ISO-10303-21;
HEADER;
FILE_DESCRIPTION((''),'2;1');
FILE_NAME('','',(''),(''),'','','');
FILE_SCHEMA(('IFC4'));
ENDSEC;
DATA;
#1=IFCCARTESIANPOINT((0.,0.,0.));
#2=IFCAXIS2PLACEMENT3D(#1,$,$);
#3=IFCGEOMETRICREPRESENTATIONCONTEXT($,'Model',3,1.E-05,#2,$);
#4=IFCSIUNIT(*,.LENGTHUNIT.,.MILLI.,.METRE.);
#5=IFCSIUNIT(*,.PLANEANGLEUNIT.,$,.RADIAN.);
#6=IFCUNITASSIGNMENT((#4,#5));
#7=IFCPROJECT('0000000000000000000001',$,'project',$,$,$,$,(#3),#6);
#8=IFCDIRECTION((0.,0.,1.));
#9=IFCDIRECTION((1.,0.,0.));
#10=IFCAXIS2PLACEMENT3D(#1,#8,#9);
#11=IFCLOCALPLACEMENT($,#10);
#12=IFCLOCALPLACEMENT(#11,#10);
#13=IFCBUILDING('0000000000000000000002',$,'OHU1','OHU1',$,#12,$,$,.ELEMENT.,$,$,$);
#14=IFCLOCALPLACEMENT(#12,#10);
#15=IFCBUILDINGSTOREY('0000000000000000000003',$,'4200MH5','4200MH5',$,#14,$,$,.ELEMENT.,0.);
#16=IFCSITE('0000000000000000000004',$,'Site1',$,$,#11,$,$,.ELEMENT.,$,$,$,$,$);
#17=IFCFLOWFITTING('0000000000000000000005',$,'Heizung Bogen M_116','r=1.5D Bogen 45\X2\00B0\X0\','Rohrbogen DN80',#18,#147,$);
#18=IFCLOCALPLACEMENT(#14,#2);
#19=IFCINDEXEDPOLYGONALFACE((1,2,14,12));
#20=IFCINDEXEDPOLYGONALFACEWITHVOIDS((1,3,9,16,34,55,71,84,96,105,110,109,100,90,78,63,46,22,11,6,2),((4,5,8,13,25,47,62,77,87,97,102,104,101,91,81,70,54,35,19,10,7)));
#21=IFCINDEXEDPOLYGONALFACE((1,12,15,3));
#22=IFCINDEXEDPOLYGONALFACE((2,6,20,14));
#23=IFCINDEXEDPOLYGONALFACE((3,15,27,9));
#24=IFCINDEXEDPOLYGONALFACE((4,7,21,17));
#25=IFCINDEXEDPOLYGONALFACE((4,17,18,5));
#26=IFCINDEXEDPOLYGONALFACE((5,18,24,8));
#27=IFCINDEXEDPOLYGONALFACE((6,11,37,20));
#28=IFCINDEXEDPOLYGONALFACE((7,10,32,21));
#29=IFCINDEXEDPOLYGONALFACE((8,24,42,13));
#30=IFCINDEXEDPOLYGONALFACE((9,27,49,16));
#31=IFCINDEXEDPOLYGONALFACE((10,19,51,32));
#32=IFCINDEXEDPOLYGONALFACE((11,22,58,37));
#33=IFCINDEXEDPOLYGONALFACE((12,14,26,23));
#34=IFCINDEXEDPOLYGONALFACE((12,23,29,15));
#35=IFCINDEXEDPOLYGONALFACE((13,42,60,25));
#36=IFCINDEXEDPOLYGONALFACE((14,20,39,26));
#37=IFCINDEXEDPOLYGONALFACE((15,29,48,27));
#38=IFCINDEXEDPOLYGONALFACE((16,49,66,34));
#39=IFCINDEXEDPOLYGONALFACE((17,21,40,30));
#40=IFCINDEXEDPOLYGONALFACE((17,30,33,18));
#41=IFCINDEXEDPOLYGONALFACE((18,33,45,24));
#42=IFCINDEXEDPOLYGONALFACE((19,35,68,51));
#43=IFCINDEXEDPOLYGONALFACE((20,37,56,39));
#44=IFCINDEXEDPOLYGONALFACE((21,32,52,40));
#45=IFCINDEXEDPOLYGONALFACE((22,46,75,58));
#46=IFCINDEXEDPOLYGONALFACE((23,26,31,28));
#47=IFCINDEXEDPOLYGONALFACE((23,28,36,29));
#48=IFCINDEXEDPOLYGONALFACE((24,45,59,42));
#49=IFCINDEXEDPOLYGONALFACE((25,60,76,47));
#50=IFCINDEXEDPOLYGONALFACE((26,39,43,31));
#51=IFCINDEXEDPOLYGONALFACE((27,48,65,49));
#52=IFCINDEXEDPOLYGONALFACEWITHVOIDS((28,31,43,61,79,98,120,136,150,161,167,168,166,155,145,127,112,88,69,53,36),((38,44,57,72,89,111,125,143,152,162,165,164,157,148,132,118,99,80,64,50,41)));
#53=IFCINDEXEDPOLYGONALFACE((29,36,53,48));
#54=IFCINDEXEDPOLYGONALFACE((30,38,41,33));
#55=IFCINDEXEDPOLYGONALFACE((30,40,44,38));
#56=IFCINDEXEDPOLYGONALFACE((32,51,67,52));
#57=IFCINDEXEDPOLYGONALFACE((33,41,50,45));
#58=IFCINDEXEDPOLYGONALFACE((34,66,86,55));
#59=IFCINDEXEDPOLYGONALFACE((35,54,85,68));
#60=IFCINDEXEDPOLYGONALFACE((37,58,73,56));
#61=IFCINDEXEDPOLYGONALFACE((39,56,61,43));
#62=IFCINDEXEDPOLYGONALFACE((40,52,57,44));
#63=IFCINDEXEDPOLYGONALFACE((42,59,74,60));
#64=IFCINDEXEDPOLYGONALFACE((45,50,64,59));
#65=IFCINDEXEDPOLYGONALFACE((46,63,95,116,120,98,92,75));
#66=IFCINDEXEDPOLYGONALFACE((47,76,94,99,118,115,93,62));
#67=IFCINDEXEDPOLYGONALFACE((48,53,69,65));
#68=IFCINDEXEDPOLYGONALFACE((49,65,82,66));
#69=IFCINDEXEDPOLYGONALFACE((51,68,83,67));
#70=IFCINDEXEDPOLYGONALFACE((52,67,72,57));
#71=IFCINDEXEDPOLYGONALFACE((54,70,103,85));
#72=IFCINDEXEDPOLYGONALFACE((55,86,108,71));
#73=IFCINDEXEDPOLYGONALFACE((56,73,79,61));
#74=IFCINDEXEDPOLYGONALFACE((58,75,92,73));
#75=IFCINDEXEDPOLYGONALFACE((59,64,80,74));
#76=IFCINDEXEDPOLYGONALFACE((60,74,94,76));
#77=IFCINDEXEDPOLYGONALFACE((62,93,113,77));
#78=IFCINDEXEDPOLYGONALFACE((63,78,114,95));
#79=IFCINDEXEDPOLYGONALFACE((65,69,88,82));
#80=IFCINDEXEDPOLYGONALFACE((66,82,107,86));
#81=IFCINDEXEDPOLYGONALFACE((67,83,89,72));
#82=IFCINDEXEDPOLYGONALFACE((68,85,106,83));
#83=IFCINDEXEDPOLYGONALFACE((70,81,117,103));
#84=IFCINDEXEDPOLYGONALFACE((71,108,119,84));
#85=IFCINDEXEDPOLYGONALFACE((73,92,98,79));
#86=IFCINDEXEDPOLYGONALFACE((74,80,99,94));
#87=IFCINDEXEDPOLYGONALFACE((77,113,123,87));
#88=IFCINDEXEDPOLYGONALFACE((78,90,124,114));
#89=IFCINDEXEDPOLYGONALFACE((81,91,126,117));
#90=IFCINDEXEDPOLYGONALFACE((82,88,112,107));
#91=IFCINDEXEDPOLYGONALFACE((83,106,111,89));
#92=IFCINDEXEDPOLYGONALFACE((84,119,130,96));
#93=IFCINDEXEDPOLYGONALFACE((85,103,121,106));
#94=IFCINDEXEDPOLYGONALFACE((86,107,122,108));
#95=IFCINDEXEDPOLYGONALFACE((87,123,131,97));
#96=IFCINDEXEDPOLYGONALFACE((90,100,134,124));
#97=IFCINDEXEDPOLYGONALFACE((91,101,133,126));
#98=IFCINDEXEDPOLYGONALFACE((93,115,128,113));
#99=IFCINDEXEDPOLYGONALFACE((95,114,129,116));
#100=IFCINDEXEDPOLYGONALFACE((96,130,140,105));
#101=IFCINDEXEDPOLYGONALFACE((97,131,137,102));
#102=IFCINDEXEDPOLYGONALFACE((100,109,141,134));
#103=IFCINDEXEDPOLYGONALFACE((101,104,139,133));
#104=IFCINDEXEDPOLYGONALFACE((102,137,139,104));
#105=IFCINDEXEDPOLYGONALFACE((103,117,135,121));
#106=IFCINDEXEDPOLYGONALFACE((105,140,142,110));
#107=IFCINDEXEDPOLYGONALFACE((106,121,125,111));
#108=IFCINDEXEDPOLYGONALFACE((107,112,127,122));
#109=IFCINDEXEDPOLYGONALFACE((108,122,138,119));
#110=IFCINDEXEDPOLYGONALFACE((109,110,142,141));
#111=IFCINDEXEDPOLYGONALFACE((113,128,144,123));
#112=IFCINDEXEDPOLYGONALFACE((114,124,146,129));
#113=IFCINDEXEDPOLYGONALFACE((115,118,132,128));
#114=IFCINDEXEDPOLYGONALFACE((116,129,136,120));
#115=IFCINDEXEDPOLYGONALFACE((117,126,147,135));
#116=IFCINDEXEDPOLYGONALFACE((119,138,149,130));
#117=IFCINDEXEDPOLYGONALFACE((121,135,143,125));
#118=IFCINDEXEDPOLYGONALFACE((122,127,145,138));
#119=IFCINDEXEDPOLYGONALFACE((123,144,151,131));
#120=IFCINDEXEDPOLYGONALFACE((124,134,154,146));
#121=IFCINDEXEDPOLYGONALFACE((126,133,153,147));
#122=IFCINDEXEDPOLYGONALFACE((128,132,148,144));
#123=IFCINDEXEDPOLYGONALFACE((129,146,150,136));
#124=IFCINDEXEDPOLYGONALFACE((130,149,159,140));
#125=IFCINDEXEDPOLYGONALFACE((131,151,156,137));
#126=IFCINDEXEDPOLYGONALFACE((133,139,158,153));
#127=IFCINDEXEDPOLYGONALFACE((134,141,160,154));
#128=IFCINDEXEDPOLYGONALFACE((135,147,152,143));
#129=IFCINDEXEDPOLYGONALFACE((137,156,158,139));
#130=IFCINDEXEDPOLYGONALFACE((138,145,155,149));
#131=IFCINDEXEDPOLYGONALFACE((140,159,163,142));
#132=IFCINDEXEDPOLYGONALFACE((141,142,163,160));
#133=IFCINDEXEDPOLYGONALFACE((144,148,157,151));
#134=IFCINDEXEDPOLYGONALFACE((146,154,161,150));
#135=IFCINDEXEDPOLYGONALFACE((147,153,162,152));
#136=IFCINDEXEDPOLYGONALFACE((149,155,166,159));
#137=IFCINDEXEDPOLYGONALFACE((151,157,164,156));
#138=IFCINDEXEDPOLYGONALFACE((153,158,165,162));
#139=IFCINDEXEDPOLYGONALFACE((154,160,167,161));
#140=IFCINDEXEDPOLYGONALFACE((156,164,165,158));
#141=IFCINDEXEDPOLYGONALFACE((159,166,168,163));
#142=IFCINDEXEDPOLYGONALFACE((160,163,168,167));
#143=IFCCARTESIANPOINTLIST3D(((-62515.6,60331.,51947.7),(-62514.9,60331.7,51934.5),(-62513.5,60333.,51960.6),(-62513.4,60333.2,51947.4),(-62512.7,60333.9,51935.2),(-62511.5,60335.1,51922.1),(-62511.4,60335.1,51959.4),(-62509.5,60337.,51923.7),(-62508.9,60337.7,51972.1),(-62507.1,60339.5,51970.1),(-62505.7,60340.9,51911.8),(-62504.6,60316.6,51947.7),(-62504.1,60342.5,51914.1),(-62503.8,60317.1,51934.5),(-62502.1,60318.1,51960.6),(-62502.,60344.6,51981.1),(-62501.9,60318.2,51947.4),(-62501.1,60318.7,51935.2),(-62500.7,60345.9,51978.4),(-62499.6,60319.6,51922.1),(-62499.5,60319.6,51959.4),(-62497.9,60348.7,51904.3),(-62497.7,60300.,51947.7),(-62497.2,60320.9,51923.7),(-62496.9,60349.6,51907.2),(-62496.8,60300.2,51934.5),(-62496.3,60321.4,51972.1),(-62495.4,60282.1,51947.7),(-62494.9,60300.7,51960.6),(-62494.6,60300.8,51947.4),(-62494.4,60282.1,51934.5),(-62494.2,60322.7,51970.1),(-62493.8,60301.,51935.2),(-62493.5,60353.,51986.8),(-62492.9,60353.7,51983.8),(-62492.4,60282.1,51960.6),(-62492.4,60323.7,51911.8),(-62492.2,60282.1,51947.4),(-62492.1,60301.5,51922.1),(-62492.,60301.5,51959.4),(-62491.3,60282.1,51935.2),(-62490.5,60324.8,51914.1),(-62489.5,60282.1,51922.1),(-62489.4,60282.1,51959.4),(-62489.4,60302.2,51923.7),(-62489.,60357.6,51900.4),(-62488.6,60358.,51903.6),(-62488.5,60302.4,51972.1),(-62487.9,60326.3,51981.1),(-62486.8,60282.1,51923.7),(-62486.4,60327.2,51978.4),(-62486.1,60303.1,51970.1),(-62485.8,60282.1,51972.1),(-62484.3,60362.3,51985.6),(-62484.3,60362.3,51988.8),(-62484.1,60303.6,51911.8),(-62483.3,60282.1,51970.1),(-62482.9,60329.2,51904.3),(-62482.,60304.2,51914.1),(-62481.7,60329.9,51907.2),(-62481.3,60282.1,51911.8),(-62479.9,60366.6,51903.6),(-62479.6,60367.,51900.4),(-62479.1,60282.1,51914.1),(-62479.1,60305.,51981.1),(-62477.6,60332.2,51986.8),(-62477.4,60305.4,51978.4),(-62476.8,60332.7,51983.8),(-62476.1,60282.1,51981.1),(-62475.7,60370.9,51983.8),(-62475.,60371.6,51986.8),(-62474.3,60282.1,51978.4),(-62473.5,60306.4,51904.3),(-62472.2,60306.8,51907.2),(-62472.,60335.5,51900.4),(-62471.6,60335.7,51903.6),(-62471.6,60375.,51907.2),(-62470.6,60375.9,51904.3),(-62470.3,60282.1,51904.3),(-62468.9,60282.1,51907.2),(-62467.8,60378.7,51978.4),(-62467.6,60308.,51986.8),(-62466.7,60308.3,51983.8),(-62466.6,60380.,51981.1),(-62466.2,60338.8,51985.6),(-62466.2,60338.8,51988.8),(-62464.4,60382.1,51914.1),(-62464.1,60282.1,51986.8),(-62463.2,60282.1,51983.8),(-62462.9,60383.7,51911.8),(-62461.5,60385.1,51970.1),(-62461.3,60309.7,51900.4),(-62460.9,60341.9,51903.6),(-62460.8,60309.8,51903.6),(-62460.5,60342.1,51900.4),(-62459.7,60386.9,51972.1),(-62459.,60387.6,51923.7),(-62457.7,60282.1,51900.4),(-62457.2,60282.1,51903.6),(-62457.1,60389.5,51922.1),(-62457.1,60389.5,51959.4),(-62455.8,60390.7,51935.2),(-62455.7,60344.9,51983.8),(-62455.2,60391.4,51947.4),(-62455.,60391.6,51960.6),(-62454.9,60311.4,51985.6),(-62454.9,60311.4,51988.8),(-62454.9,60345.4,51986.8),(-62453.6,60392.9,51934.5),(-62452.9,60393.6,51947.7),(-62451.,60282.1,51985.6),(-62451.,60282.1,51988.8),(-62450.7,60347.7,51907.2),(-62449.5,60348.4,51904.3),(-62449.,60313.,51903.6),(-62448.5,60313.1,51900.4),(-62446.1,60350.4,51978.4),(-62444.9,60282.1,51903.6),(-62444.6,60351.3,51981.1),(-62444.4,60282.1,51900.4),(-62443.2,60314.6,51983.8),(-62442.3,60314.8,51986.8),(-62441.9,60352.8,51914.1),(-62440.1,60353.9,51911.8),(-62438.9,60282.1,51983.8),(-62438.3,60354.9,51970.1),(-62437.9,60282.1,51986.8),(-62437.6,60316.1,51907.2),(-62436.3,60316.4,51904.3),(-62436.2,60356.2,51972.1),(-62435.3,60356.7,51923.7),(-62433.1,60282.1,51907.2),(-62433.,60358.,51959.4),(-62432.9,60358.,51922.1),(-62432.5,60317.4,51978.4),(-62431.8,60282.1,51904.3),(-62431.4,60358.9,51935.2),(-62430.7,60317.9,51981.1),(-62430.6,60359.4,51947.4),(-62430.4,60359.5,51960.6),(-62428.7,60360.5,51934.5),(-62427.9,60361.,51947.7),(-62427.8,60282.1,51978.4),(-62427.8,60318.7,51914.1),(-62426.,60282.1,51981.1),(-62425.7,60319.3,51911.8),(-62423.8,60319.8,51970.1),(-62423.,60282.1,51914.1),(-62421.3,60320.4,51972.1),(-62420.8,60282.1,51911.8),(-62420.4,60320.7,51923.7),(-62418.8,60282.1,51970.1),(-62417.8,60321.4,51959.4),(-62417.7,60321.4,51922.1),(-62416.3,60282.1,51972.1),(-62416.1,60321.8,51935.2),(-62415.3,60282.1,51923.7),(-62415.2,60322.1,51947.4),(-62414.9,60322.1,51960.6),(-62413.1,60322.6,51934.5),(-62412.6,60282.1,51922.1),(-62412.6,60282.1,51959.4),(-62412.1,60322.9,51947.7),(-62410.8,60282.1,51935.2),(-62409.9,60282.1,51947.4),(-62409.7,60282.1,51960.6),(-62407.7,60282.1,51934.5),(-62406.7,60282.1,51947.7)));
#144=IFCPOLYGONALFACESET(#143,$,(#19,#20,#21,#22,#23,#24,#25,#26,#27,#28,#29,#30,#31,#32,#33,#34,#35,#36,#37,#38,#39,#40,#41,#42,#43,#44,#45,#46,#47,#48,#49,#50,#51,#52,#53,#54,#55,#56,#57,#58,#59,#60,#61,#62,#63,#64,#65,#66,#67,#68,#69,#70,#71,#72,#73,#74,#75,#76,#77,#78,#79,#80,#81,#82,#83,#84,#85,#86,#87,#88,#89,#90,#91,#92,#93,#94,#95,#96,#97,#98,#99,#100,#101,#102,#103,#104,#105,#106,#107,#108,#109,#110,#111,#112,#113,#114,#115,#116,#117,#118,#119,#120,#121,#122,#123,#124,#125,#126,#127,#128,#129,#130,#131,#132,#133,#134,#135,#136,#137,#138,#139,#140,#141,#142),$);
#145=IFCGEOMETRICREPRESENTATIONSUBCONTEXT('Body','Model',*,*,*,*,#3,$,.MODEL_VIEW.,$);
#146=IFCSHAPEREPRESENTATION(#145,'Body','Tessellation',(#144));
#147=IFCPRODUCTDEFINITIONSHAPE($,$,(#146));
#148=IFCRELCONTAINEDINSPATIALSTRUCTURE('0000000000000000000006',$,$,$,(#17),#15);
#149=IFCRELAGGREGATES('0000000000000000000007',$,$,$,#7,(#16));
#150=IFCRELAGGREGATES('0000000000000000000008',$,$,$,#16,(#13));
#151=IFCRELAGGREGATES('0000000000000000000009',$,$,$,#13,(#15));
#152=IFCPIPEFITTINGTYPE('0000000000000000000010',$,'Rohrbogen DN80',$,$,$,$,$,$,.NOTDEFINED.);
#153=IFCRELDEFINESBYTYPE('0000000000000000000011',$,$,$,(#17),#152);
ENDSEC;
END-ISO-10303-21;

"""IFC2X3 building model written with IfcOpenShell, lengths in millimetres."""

from ifc_helpers import new_model, entity, si_unit, frame, origin, origin_with_axes, place, context, subcontext, project, spatial, type_object, element, save


model = new_model("IFC2X3")

# Units and contexts
model_context = context("Model", 3, precision=1e-05, world=origin())
body_context = subcontext(model_context, "Body", "Model", "MODEL_VIEW")
ifc_project = project(units=[si_unit("LENGTHUNIT", "METRE", prefix="MILLI"), si_unit("PLANEANGLEUNIT", "RADIAN")], contexts=[model_context])

# Site, building, storey
site_placement = place(None, origin_with_axes())
site = spatial("IfcSite", under=ifc_project, at=site_placement, Name="Site1", CompositionType="ELEMENT")
building_placement = place(site_placement, origin_with_axes())
building = spatial("IfcBuilding", under=site, at=building_placement, Name="OHU1", Description="OHU1", CompositionType="ELEMENT")
storey_placement = place(building_placement, origin_with_axes())
storey = spatial("IfcBuildingStorey", under=building, at=storey_placement, Name="4200MH5", Description="4200MH5", CompositionType="ELEMENT", Elevation=0.0)

# Flow fitting
pipe_fitting_type_1 = type_object("IfcPipeFittingType", Name="Rohrbogen DN80", PredefinedType="NOTDEFINED")
flow_fitting_1_placement = place(storey_placement, frame((-62427.6, 60305.7, 51944.4), z_axis=(0.0, 0.0, 1.0), x_axis=(1.0, 0.0, 0.0)))
element("IfcFlowFitting", 1, at=flow_fitting_1_placement, inside=storey, type_object=pipe_fitting_type_1, Name="Heizung Bogen M_116", Description="r=1.5D Bogen 45°", ObjectType="Rohrbogen DN80", context=body_context, shape_type="SweptSolid", body=[
    entity("IfcRevolvedAreaSolid", entity("IfcCircleHollowProfileDef", "AREA", None, entity("IfcAxis2Placement2D", entity("IfcCartesianPoint", [0.0, 0.0]), entity("IfcDirection", [1.0, 0.0])), 44.5, 3.2), entity("IfcAxis2Placement3D", entity("IfcCartesianPoint", [-56.6, 56.6, 0.0]), entity("IfcDirection", [0.707104, -0.707109, 0.0]), entity("IfcDirection", [0.0, 0.0, 1.0])), entity("IfcAxis1Placement", entity("IfcCartesianPoint", [0.0, 113.5, 0.0]), entity("IfcDirection", [-1.0, 0.0, 0.0])), 0.785398),
])

save(model, "model.ifc")
